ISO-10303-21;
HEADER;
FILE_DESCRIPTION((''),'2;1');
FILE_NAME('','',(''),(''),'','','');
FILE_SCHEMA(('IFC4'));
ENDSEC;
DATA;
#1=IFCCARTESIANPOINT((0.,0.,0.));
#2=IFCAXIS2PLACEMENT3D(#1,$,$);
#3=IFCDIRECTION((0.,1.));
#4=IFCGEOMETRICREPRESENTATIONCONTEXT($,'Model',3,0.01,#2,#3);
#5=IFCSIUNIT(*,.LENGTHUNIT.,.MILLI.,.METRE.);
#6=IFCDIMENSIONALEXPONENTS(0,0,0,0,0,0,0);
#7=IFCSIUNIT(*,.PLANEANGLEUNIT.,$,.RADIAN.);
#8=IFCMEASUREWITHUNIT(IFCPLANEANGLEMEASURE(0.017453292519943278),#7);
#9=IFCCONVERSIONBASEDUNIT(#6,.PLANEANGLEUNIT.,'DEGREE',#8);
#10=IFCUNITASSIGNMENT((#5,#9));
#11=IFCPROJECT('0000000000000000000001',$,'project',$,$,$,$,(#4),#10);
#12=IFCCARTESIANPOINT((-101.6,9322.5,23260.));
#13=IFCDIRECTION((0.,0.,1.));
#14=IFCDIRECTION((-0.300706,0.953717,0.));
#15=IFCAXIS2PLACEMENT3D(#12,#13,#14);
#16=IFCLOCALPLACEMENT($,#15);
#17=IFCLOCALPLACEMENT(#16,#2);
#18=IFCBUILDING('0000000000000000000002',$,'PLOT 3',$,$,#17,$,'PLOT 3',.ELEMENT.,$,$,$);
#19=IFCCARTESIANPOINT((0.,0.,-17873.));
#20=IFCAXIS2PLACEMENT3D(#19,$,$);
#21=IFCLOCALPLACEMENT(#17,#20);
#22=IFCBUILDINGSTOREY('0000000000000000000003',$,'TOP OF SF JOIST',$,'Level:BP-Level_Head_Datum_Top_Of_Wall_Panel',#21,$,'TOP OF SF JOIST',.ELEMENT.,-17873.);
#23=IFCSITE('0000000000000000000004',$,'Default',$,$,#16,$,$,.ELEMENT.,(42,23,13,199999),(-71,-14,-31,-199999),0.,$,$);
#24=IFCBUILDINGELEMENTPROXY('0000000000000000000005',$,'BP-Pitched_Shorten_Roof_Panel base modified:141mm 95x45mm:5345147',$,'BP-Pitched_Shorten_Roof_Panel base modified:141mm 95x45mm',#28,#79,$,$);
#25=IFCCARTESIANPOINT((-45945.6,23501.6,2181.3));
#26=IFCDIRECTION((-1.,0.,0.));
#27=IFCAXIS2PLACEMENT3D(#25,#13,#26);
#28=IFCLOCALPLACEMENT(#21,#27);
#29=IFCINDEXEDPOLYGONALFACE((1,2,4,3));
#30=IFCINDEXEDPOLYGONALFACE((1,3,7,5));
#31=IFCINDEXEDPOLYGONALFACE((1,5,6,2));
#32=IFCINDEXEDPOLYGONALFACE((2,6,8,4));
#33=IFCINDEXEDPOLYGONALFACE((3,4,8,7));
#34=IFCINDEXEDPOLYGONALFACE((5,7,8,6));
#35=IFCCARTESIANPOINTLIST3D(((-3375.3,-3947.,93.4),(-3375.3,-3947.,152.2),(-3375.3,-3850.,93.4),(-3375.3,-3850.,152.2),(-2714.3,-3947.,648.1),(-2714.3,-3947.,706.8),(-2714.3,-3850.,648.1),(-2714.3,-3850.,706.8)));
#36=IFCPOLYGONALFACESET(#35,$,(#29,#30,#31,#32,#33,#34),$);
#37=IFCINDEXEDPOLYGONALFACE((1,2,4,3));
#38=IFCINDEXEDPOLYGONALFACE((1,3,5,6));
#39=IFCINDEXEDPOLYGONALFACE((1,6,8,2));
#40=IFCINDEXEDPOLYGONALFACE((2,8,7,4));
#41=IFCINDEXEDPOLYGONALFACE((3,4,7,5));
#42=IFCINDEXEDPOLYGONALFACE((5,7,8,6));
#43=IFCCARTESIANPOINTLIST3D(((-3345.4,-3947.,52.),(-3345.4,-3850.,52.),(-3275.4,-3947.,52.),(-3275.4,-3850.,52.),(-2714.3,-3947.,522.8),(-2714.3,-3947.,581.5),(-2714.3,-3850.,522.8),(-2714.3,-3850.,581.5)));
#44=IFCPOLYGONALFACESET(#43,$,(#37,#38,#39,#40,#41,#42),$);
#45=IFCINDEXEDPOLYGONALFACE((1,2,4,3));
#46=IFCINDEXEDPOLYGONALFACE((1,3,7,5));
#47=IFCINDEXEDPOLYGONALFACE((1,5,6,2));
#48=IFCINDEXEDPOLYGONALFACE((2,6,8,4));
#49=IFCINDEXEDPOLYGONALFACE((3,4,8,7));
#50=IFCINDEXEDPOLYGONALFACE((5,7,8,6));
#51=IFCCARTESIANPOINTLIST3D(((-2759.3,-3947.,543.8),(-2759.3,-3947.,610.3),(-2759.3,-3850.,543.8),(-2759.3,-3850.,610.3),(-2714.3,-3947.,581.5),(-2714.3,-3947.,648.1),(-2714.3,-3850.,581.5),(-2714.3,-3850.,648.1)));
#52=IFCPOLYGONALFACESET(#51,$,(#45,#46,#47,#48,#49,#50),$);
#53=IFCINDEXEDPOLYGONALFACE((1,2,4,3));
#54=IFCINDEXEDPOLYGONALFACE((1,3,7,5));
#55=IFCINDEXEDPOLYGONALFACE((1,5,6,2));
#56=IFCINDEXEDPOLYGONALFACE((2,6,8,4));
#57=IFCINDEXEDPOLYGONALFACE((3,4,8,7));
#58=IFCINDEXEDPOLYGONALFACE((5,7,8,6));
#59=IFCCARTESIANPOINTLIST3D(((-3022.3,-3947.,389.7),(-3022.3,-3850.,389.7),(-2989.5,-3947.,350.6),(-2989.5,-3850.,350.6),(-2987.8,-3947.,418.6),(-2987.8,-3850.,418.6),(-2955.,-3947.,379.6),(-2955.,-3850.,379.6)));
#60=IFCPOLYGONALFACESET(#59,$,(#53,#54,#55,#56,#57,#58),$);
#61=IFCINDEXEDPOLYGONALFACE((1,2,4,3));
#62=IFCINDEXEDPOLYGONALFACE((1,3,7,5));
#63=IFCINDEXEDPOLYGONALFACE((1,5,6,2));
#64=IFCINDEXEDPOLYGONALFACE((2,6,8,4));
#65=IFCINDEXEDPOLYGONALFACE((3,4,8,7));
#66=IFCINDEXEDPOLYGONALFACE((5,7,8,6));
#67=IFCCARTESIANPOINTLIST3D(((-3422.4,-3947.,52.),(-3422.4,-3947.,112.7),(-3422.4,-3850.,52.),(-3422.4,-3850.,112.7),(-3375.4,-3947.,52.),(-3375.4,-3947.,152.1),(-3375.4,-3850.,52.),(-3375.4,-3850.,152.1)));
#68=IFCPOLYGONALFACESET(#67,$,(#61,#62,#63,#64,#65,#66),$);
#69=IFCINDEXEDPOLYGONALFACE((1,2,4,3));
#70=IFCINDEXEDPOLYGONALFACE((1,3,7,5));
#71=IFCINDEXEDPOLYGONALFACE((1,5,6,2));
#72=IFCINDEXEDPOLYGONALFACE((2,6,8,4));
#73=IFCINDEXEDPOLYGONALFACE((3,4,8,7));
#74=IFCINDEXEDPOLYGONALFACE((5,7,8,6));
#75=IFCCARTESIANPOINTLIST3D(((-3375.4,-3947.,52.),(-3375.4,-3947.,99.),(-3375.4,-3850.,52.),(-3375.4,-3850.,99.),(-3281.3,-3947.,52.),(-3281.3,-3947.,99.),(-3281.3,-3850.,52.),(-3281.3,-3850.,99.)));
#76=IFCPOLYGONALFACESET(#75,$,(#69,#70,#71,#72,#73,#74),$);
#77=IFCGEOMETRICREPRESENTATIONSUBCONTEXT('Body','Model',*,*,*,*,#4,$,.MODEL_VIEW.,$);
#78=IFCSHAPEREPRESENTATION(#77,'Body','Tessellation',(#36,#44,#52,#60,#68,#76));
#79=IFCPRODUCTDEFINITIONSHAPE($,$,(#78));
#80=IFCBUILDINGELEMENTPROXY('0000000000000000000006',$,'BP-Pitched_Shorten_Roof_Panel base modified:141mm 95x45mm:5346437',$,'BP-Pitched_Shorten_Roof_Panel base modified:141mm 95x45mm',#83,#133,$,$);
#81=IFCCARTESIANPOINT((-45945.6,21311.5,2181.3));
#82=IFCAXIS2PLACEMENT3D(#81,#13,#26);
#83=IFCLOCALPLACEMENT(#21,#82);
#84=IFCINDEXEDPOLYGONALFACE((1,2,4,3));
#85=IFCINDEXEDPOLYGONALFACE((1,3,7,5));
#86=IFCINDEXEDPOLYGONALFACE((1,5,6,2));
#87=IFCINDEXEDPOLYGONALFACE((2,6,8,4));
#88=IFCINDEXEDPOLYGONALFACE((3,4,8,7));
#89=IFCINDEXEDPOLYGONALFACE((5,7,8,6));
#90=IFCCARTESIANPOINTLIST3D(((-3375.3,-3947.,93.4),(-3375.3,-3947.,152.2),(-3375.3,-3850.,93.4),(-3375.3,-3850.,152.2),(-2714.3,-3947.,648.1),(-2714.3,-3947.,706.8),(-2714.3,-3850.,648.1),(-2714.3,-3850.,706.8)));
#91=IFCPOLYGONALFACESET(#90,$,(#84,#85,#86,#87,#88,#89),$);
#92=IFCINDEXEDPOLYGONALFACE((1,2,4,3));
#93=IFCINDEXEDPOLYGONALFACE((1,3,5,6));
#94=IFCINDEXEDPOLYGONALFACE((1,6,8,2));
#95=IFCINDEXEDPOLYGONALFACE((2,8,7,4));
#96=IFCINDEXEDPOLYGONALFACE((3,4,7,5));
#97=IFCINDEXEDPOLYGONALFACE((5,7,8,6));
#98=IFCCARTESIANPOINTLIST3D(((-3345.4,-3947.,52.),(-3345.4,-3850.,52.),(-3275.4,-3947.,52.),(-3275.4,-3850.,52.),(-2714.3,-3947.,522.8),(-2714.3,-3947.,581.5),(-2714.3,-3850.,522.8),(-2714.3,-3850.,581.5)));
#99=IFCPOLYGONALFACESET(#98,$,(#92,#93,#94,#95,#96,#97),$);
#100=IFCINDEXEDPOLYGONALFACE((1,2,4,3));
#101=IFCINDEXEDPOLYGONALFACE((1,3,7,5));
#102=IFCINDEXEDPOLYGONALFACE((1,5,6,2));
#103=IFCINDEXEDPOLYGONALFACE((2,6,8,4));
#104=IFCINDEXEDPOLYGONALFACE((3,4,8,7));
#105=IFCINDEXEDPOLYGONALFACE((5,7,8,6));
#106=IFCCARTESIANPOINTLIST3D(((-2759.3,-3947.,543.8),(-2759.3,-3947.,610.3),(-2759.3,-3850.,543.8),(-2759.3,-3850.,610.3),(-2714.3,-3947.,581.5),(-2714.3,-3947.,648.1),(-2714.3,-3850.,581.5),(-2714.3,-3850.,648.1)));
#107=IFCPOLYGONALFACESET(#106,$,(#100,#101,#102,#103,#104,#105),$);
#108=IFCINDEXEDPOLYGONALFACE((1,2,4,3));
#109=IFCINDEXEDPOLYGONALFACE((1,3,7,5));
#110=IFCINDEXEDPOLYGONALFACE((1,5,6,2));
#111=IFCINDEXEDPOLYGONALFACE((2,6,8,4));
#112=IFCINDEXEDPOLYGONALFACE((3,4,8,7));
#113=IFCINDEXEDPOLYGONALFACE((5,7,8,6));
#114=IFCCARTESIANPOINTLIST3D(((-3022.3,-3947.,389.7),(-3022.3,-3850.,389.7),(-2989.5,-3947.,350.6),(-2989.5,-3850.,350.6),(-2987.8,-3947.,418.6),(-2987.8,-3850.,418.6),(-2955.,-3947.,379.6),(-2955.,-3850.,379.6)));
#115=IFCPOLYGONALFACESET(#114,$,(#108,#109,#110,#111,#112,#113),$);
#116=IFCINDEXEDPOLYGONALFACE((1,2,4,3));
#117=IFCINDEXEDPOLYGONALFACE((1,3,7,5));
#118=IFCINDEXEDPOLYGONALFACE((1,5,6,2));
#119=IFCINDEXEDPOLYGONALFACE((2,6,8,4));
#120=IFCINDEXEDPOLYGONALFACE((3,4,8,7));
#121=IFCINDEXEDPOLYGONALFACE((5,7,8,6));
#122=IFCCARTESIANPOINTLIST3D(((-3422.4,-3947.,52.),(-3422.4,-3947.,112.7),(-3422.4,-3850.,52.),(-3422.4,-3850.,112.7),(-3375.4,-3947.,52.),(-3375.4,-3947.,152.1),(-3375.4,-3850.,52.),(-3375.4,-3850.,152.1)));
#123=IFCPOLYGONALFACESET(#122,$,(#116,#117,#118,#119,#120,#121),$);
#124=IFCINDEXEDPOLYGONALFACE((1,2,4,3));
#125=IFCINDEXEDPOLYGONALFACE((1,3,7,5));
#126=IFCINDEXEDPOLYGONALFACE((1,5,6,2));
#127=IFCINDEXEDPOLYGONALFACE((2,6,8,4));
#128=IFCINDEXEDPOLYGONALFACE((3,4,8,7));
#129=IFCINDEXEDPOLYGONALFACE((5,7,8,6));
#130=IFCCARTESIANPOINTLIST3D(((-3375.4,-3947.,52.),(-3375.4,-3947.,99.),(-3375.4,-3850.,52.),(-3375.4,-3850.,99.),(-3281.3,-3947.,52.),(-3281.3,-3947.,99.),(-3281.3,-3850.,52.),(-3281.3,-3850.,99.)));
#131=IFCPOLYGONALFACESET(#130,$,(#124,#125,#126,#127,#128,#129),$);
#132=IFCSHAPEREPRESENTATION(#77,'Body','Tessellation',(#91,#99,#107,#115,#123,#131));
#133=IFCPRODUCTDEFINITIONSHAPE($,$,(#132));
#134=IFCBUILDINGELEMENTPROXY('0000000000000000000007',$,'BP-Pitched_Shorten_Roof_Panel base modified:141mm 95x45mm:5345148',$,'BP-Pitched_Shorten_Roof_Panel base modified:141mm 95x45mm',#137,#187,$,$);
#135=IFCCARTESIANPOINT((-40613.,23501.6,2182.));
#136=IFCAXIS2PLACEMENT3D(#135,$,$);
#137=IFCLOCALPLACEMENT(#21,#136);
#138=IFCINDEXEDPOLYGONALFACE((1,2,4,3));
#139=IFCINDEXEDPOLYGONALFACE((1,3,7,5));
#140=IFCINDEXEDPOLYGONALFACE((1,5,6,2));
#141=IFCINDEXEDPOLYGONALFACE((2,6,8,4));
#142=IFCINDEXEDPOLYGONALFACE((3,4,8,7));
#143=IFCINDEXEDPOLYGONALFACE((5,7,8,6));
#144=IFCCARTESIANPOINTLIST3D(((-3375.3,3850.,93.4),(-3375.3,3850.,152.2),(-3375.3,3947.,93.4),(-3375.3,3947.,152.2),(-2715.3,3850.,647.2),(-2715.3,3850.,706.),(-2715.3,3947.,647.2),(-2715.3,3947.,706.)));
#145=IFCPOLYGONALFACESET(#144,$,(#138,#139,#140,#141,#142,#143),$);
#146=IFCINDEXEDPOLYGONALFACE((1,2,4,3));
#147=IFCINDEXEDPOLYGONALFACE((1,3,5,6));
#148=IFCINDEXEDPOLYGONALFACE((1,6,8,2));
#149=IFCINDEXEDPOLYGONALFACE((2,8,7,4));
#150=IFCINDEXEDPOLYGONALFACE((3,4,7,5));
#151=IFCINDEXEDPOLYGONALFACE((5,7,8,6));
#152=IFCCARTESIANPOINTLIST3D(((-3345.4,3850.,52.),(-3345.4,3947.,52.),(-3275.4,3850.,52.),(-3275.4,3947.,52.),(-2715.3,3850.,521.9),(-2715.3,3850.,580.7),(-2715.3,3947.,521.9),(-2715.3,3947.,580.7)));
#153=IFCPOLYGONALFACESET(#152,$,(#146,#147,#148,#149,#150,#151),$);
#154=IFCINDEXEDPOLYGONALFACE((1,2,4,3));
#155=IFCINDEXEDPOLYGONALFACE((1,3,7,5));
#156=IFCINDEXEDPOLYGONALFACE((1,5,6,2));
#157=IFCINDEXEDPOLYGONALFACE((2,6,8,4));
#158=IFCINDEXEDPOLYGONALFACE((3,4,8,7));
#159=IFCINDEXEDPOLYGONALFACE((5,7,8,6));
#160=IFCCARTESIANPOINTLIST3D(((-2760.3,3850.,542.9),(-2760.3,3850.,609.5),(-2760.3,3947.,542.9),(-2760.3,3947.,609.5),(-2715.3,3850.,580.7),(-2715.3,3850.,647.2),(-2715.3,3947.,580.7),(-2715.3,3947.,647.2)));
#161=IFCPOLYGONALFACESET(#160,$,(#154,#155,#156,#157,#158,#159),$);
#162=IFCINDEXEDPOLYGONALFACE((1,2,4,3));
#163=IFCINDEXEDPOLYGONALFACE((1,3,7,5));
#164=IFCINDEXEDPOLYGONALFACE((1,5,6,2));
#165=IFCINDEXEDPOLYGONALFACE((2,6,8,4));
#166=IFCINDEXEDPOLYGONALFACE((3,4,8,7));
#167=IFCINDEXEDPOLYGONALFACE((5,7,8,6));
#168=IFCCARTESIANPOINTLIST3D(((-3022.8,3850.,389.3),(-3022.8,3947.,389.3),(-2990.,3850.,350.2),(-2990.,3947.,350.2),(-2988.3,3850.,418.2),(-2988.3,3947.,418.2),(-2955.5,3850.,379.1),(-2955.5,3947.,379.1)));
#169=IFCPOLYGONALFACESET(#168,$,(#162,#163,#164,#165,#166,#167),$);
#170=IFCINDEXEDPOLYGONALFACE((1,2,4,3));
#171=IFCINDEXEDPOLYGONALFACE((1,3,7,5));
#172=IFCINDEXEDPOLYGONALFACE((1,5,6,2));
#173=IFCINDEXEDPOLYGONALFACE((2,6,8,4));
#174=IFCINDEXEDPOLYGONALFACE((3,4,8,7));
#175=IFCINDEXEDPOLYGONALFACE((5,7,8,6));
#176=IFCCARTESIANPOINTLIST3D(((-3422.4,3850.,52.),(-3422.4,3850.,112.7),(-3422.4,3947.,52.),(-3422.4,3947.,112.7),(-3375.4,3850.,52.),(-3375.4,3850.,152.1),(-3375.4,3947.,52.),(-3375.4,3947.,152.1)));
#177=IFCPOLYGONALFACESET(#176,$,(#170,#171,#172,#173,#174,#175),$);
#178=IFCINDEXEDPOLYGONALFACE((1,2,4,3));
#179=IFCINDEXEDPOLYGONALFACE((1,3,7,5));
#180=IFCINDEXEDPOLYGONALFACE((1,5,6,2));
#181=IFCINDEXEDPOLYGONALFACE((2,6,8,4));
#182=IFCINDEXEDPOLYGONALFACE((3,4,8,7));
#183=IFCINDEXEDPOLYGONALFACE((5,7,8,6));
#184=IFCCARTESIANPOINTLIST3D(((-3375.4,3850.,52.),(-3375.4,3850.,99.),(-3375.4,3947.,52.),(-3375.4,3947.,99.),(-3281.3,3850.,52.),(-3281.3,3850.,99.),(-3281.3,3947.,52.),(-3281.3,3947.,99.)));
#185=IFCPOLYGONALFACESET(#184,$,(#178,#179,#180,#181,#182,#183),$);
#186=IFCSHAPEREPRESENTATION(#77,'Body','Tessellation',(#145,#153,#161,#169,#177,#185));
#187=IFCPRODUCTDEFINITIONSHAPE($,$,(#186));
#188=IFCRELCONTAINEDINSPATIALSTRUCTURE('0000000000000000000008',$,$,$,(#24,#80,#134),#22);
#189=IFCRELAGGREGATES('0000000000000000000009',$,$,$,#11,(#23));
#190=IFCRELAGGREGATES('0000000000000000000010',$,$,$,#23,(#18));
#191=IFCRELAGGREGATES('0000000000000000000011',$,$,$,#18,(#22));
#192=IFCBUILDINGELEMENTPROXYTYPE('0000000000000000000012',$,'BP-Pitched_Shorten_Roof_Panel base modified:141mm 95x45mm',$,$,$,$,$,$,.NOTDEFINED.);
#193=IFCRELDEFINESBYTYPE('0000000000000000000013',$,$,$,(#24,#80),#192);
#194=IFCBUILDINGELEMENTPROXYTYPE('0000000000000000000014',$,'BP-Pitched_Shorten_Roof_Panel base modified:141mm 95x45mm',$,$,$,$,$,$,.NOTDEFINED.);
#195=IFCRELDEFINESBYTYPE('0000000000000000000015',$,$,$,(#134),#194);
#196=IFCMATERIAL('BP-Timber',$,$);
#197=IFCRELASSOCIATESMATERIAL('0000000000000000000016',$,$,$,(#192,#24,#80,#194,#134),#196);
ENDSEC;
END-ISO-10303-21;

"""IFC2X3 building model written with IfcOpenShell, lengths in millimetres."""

from ifc_helpers import new_model, entity, si_unit, converted_unit, direction, frame, frame_2d, origin, origin_2d_with_axis, place, context, subcontext, project, spatial, polyline, rectangle, outline, extrude, source, transform, mapped, material, type_object, type_shapes, element, save


model = new_model("IFC2X3")

# Units and contexts
model_context = context("Model", 3, precision=0.01, world=origin(), true_north=direction((0.0, 1.0)))
body_context = subcontext(model_context, "Body", "Model", "MODEL_VIEW")
ifc_project = project(units=[si_unit("LENGTHUNIT", "METRE", prefix="MILLI"), converted_unit("PLANEANGLEUNIT", "DEGREE", entity("IfcPlaneAngleMeasure", 0.017453292519943278), si_unit("PLANEANGLEUNIT", "RADIAN"), dimensions=[0, 0, 0, 0, 0, 0, 0])], contexts=[model_context])

# Site, building, storey
site_placement = place(None, frame((-101.6, 9322.5, 23260.0), z_axis=(0.0, 0.0, 1.0), x_axis=(-0.300706, 0.953717, 0.0)))
site = spatial("IfcSite", under=ifc_project, at=site_placement, Name="Default", CompositionType="ELEMENT", RefLatitude=(42, 23, 13, 199999), RefLongitude=(-71, -14, -31, -199999), RefElevation=0.0)
building_placement = place(site_placement, origin())
building = spatial("IfcBuilding", under=site, at=building_placement, Name="PLOT 3", LongName="PLOT 3", CompositionType="ELEMENT")
storey_placement = place(building_placement, frame((0.0, 0.0, -17873.0)))
storey = spatial("IfcBuildingStorey", under=building, at=storey_placement, Name="TOP OF SF JOIST", ObjectType="Level:BP-Level_Head_Datum_Top_Of_Wall_Panel", LongName="TOP OF SF JOIST", CompositionType="ELEMENT", Elevation=-17873.0)

# Building element proxies
ifc_material_1 = material(Name="BP-Timber")
building_element_proxy_type_1 = type_object("IfcBuildingElementProxyType", Name="BP-Pitched_Shorten_Roof_Panel base modified:141mm 95x45mm", PredefinedType="NOTDEFINED", material=ifc_material_1)
shared_shape_1 = source(origin(), body_context, "Body", "SweptSolid", [
    extrude(outline(polyline([(-306.7, -330.5), (-248.0, -330.5), (306.7, 330.5), (248.0, 330.5), (-306.7, -330.5)])), frame((-3044.8, -3947.0, 400.1), z_axis=(0.0, 1.0, 0.0), x_axis=(0.0, 0.0, -1.0)), (0.0, 0.0, 1.0), 97.0),
    extrude(outline(polyline([(-279.4, -298.0), (-220.7, -298.0), (250.1, 263.0), (250.1, 333.0), (-279.4, -298.0)])), frame((-3012.4, -3947.0, 302.1), z_axis=(0.0, 1.0, 0.0), x_axis=(0.0, 0.0, -1.0)), (0.0, 0.0, 1.0), 97.0),
    extrude(outline(polyline([(-8.0, -25.5), (50.8, -25.5), (8.0, 25.5), (-50.8, 25.5), (-8.0, -25.5)])), frame((-2736.8, -3947.0, 595.9), z_axis=(0.0, 1.0, 0.0), x_axis=(0.766044, 0.0, 0.642788)), (0.0, 0.0, 1.0), 97.0),
    extrude(rectangle(XDim=51.0, YDim=45.0, at=frame_2d((0.0, 0.0), x_axis=(1.0, 0.0))), frame((-2988.6, -3947.0, 384.6), z_axis=(0.0, 1.0, 0.0), x_axis=(0.642788, 0.0, -0.766044)), (0.0, 0.0, 1.0), 97.0),
    extrude(outline(polyline([(-59.9, -23.5), (40.2, -23.5), (40.2, 23.5), (-20.5, 23.5), (-59.9, -23.5)])), frame((-3398.9, -3947.0, 92.2), z_axis=(0.0, 1.0, 0.0), x_axis=(0.0, 0.0, -1.0)), (0.0, 0.0, 1.0), 97.0),
    extrude(rectangle(XDim=94.1, YDim=97.0, at=frame_2d((0.0, 0.0), x_axis=(1.0, 0.0))), frame((-3328.4, -3898.5, 52.0), z_axis=(0.0, 0.0, 1.0), x_axis=(-1.0, 0.0, 0.0)), (0.0, 0.0, 1.0), 47.0),
])
type_shapes(building_element_proxy_type_1, [shared_shape_1])
for number, where, z_axis, x_axis, name in (
    (1, (-45945.6, 23501.6, 2181.3), (0.0, 0.0, 1.0), (-1.0, 0.0, 0.0), "BP-Pitched_Shorten_Roof_Panel base modified:141mm 95x45mm:5345147"),
    (2, (-45945.6, 21311.5, 2181.3), (0.0, 0.0, 1.0), (-1.0, 0.0, 0.0), "BP-Pitched_Shorten_Roof_Panel base modified:141mm 95x45mm:5346437"),
):
    element("IfcBuildingElementProxy", number, at=place(storey_placement, frame(where, z_axis=z_axis, x_axis=x_axis)), inside=storey, type_object=building_element_proxy_type_1, material=ifc_material_1, Name=name, ObjectType="BP-Pitched_Shorten_Roof_Panel base modified:141mm 95x45mm", context=body_context, shape_type="MappedRepresentation", body=[
        mapped(shared_shape_1, transform((0.0, 0.0, 0.0), scale=1.0)),
    ])
building_element_proxy_type_2 = type_object("IfcBuildingElementProxyType", Name="BP-Pitched_Shorten_Roof_Panel base modified:141mm 95x45mm", PredefinedType="NOTDEFINED", material=ifc_material_1)
shared_shape_2 = source(origin(), body_context, "Body", "SweptSolid", [
    extrude(outline(polyline([(-306.3, -330.0), (-247.5, -330.0), (306.3, 330.0), (247.5, 330.0), (-306.3, -330.0)])), frame((-3045.3, 3850.0, 399.7), z_axis=(0.0, 1.0, 0.0), x_axis=(0.0, 0.0, -1.0)), (0.0, 0.0, 1.0), 97.0),
    extrude(outline(polyline([(-279.0, -297.5), (-220.3, -297.5), (249.7, 262.5), (249.7, 332.5), (-279.0, -297.5)])), frame((-3012.9, 3850.0, 301.7), z_axis=(0.0, 1.0, 0.0), x_axis=(0.0, 0.0, -1.0)), (0.0, 0.0, 1.0), 97.0),
    extrude(outline(polyline([(-8.0, -25.5), (50.8, -25.5), (8.0, 25.5), (-50.8, 25.5), (-8.0, -25.5)])), frame((-2737.8, 3850.0, 595.1), z_axis=(0.0, 1.0, 0.0), x_axis=(0.766044, 0.0, 0.642788)), (0.0, 0.0, 1.0), 97.0),
    extrude(rectangle(XDim=51.0, YDim=45.0, at=origin_2d_with_axis()), frame((-2989.1, 3850.0, 384.2), z_axis=(0.0, 1.0, 0.0), x_axis=(0.642788, 0.0, -0.766044)), (0.0, 0.0, 1.0), 97.0),
    extrude(outline(polyline([(-59.9, -23.5), (40.2, -23.5), (40.2, 23.5), (-20.5, 23.5), (-59.9, -23.5)])), frame((-3398.9, 3850.0, 92.2), z_axis=(0.0, 1.0, 0.0), x_axis=(0.0, 0.0, -1.0)), (0.0, 0.0, 1.0), 97.0),
    extrude(rectangle(XDim=97.0, YDim=94.1, at=frame_2d((0.0, 0.0), x_axis=(1.0, 0.0))), frame((-3328.4, 3898.5, 52.0), z_axis=(0.0, 0.0, 1.0), x_axis=(0.0, 1.0, 0.0)), (0.0, 0.0, 1.0), 47.0),
])
type_shapes(building_element_proxy_type_2, [shared_shape_2])
proxy_1_placement = place(storey_placement, frame((-40613.0, 23501.6, 2182.0)))
element("IfcBuildingElementProxy", 3, at=proxy_1_placement, inside=storey, type_object=building_element_proxy_type_2, material=ifc_material_1, Name="BP-Pitched_Shorten_Roof_Panel base modified:141mm 95x45mm:5345148", ObjectType="BP-Pitched_Shorten_Roof_Panel base modified:141mm 95x45mm", context=body_context, shape_type="MappedRepresentation", body=[
    mapped(shared_shape_2, transform((0.0, 0.0, 0.0), scale=1.0)),
])

save(model, "model.ifc")
